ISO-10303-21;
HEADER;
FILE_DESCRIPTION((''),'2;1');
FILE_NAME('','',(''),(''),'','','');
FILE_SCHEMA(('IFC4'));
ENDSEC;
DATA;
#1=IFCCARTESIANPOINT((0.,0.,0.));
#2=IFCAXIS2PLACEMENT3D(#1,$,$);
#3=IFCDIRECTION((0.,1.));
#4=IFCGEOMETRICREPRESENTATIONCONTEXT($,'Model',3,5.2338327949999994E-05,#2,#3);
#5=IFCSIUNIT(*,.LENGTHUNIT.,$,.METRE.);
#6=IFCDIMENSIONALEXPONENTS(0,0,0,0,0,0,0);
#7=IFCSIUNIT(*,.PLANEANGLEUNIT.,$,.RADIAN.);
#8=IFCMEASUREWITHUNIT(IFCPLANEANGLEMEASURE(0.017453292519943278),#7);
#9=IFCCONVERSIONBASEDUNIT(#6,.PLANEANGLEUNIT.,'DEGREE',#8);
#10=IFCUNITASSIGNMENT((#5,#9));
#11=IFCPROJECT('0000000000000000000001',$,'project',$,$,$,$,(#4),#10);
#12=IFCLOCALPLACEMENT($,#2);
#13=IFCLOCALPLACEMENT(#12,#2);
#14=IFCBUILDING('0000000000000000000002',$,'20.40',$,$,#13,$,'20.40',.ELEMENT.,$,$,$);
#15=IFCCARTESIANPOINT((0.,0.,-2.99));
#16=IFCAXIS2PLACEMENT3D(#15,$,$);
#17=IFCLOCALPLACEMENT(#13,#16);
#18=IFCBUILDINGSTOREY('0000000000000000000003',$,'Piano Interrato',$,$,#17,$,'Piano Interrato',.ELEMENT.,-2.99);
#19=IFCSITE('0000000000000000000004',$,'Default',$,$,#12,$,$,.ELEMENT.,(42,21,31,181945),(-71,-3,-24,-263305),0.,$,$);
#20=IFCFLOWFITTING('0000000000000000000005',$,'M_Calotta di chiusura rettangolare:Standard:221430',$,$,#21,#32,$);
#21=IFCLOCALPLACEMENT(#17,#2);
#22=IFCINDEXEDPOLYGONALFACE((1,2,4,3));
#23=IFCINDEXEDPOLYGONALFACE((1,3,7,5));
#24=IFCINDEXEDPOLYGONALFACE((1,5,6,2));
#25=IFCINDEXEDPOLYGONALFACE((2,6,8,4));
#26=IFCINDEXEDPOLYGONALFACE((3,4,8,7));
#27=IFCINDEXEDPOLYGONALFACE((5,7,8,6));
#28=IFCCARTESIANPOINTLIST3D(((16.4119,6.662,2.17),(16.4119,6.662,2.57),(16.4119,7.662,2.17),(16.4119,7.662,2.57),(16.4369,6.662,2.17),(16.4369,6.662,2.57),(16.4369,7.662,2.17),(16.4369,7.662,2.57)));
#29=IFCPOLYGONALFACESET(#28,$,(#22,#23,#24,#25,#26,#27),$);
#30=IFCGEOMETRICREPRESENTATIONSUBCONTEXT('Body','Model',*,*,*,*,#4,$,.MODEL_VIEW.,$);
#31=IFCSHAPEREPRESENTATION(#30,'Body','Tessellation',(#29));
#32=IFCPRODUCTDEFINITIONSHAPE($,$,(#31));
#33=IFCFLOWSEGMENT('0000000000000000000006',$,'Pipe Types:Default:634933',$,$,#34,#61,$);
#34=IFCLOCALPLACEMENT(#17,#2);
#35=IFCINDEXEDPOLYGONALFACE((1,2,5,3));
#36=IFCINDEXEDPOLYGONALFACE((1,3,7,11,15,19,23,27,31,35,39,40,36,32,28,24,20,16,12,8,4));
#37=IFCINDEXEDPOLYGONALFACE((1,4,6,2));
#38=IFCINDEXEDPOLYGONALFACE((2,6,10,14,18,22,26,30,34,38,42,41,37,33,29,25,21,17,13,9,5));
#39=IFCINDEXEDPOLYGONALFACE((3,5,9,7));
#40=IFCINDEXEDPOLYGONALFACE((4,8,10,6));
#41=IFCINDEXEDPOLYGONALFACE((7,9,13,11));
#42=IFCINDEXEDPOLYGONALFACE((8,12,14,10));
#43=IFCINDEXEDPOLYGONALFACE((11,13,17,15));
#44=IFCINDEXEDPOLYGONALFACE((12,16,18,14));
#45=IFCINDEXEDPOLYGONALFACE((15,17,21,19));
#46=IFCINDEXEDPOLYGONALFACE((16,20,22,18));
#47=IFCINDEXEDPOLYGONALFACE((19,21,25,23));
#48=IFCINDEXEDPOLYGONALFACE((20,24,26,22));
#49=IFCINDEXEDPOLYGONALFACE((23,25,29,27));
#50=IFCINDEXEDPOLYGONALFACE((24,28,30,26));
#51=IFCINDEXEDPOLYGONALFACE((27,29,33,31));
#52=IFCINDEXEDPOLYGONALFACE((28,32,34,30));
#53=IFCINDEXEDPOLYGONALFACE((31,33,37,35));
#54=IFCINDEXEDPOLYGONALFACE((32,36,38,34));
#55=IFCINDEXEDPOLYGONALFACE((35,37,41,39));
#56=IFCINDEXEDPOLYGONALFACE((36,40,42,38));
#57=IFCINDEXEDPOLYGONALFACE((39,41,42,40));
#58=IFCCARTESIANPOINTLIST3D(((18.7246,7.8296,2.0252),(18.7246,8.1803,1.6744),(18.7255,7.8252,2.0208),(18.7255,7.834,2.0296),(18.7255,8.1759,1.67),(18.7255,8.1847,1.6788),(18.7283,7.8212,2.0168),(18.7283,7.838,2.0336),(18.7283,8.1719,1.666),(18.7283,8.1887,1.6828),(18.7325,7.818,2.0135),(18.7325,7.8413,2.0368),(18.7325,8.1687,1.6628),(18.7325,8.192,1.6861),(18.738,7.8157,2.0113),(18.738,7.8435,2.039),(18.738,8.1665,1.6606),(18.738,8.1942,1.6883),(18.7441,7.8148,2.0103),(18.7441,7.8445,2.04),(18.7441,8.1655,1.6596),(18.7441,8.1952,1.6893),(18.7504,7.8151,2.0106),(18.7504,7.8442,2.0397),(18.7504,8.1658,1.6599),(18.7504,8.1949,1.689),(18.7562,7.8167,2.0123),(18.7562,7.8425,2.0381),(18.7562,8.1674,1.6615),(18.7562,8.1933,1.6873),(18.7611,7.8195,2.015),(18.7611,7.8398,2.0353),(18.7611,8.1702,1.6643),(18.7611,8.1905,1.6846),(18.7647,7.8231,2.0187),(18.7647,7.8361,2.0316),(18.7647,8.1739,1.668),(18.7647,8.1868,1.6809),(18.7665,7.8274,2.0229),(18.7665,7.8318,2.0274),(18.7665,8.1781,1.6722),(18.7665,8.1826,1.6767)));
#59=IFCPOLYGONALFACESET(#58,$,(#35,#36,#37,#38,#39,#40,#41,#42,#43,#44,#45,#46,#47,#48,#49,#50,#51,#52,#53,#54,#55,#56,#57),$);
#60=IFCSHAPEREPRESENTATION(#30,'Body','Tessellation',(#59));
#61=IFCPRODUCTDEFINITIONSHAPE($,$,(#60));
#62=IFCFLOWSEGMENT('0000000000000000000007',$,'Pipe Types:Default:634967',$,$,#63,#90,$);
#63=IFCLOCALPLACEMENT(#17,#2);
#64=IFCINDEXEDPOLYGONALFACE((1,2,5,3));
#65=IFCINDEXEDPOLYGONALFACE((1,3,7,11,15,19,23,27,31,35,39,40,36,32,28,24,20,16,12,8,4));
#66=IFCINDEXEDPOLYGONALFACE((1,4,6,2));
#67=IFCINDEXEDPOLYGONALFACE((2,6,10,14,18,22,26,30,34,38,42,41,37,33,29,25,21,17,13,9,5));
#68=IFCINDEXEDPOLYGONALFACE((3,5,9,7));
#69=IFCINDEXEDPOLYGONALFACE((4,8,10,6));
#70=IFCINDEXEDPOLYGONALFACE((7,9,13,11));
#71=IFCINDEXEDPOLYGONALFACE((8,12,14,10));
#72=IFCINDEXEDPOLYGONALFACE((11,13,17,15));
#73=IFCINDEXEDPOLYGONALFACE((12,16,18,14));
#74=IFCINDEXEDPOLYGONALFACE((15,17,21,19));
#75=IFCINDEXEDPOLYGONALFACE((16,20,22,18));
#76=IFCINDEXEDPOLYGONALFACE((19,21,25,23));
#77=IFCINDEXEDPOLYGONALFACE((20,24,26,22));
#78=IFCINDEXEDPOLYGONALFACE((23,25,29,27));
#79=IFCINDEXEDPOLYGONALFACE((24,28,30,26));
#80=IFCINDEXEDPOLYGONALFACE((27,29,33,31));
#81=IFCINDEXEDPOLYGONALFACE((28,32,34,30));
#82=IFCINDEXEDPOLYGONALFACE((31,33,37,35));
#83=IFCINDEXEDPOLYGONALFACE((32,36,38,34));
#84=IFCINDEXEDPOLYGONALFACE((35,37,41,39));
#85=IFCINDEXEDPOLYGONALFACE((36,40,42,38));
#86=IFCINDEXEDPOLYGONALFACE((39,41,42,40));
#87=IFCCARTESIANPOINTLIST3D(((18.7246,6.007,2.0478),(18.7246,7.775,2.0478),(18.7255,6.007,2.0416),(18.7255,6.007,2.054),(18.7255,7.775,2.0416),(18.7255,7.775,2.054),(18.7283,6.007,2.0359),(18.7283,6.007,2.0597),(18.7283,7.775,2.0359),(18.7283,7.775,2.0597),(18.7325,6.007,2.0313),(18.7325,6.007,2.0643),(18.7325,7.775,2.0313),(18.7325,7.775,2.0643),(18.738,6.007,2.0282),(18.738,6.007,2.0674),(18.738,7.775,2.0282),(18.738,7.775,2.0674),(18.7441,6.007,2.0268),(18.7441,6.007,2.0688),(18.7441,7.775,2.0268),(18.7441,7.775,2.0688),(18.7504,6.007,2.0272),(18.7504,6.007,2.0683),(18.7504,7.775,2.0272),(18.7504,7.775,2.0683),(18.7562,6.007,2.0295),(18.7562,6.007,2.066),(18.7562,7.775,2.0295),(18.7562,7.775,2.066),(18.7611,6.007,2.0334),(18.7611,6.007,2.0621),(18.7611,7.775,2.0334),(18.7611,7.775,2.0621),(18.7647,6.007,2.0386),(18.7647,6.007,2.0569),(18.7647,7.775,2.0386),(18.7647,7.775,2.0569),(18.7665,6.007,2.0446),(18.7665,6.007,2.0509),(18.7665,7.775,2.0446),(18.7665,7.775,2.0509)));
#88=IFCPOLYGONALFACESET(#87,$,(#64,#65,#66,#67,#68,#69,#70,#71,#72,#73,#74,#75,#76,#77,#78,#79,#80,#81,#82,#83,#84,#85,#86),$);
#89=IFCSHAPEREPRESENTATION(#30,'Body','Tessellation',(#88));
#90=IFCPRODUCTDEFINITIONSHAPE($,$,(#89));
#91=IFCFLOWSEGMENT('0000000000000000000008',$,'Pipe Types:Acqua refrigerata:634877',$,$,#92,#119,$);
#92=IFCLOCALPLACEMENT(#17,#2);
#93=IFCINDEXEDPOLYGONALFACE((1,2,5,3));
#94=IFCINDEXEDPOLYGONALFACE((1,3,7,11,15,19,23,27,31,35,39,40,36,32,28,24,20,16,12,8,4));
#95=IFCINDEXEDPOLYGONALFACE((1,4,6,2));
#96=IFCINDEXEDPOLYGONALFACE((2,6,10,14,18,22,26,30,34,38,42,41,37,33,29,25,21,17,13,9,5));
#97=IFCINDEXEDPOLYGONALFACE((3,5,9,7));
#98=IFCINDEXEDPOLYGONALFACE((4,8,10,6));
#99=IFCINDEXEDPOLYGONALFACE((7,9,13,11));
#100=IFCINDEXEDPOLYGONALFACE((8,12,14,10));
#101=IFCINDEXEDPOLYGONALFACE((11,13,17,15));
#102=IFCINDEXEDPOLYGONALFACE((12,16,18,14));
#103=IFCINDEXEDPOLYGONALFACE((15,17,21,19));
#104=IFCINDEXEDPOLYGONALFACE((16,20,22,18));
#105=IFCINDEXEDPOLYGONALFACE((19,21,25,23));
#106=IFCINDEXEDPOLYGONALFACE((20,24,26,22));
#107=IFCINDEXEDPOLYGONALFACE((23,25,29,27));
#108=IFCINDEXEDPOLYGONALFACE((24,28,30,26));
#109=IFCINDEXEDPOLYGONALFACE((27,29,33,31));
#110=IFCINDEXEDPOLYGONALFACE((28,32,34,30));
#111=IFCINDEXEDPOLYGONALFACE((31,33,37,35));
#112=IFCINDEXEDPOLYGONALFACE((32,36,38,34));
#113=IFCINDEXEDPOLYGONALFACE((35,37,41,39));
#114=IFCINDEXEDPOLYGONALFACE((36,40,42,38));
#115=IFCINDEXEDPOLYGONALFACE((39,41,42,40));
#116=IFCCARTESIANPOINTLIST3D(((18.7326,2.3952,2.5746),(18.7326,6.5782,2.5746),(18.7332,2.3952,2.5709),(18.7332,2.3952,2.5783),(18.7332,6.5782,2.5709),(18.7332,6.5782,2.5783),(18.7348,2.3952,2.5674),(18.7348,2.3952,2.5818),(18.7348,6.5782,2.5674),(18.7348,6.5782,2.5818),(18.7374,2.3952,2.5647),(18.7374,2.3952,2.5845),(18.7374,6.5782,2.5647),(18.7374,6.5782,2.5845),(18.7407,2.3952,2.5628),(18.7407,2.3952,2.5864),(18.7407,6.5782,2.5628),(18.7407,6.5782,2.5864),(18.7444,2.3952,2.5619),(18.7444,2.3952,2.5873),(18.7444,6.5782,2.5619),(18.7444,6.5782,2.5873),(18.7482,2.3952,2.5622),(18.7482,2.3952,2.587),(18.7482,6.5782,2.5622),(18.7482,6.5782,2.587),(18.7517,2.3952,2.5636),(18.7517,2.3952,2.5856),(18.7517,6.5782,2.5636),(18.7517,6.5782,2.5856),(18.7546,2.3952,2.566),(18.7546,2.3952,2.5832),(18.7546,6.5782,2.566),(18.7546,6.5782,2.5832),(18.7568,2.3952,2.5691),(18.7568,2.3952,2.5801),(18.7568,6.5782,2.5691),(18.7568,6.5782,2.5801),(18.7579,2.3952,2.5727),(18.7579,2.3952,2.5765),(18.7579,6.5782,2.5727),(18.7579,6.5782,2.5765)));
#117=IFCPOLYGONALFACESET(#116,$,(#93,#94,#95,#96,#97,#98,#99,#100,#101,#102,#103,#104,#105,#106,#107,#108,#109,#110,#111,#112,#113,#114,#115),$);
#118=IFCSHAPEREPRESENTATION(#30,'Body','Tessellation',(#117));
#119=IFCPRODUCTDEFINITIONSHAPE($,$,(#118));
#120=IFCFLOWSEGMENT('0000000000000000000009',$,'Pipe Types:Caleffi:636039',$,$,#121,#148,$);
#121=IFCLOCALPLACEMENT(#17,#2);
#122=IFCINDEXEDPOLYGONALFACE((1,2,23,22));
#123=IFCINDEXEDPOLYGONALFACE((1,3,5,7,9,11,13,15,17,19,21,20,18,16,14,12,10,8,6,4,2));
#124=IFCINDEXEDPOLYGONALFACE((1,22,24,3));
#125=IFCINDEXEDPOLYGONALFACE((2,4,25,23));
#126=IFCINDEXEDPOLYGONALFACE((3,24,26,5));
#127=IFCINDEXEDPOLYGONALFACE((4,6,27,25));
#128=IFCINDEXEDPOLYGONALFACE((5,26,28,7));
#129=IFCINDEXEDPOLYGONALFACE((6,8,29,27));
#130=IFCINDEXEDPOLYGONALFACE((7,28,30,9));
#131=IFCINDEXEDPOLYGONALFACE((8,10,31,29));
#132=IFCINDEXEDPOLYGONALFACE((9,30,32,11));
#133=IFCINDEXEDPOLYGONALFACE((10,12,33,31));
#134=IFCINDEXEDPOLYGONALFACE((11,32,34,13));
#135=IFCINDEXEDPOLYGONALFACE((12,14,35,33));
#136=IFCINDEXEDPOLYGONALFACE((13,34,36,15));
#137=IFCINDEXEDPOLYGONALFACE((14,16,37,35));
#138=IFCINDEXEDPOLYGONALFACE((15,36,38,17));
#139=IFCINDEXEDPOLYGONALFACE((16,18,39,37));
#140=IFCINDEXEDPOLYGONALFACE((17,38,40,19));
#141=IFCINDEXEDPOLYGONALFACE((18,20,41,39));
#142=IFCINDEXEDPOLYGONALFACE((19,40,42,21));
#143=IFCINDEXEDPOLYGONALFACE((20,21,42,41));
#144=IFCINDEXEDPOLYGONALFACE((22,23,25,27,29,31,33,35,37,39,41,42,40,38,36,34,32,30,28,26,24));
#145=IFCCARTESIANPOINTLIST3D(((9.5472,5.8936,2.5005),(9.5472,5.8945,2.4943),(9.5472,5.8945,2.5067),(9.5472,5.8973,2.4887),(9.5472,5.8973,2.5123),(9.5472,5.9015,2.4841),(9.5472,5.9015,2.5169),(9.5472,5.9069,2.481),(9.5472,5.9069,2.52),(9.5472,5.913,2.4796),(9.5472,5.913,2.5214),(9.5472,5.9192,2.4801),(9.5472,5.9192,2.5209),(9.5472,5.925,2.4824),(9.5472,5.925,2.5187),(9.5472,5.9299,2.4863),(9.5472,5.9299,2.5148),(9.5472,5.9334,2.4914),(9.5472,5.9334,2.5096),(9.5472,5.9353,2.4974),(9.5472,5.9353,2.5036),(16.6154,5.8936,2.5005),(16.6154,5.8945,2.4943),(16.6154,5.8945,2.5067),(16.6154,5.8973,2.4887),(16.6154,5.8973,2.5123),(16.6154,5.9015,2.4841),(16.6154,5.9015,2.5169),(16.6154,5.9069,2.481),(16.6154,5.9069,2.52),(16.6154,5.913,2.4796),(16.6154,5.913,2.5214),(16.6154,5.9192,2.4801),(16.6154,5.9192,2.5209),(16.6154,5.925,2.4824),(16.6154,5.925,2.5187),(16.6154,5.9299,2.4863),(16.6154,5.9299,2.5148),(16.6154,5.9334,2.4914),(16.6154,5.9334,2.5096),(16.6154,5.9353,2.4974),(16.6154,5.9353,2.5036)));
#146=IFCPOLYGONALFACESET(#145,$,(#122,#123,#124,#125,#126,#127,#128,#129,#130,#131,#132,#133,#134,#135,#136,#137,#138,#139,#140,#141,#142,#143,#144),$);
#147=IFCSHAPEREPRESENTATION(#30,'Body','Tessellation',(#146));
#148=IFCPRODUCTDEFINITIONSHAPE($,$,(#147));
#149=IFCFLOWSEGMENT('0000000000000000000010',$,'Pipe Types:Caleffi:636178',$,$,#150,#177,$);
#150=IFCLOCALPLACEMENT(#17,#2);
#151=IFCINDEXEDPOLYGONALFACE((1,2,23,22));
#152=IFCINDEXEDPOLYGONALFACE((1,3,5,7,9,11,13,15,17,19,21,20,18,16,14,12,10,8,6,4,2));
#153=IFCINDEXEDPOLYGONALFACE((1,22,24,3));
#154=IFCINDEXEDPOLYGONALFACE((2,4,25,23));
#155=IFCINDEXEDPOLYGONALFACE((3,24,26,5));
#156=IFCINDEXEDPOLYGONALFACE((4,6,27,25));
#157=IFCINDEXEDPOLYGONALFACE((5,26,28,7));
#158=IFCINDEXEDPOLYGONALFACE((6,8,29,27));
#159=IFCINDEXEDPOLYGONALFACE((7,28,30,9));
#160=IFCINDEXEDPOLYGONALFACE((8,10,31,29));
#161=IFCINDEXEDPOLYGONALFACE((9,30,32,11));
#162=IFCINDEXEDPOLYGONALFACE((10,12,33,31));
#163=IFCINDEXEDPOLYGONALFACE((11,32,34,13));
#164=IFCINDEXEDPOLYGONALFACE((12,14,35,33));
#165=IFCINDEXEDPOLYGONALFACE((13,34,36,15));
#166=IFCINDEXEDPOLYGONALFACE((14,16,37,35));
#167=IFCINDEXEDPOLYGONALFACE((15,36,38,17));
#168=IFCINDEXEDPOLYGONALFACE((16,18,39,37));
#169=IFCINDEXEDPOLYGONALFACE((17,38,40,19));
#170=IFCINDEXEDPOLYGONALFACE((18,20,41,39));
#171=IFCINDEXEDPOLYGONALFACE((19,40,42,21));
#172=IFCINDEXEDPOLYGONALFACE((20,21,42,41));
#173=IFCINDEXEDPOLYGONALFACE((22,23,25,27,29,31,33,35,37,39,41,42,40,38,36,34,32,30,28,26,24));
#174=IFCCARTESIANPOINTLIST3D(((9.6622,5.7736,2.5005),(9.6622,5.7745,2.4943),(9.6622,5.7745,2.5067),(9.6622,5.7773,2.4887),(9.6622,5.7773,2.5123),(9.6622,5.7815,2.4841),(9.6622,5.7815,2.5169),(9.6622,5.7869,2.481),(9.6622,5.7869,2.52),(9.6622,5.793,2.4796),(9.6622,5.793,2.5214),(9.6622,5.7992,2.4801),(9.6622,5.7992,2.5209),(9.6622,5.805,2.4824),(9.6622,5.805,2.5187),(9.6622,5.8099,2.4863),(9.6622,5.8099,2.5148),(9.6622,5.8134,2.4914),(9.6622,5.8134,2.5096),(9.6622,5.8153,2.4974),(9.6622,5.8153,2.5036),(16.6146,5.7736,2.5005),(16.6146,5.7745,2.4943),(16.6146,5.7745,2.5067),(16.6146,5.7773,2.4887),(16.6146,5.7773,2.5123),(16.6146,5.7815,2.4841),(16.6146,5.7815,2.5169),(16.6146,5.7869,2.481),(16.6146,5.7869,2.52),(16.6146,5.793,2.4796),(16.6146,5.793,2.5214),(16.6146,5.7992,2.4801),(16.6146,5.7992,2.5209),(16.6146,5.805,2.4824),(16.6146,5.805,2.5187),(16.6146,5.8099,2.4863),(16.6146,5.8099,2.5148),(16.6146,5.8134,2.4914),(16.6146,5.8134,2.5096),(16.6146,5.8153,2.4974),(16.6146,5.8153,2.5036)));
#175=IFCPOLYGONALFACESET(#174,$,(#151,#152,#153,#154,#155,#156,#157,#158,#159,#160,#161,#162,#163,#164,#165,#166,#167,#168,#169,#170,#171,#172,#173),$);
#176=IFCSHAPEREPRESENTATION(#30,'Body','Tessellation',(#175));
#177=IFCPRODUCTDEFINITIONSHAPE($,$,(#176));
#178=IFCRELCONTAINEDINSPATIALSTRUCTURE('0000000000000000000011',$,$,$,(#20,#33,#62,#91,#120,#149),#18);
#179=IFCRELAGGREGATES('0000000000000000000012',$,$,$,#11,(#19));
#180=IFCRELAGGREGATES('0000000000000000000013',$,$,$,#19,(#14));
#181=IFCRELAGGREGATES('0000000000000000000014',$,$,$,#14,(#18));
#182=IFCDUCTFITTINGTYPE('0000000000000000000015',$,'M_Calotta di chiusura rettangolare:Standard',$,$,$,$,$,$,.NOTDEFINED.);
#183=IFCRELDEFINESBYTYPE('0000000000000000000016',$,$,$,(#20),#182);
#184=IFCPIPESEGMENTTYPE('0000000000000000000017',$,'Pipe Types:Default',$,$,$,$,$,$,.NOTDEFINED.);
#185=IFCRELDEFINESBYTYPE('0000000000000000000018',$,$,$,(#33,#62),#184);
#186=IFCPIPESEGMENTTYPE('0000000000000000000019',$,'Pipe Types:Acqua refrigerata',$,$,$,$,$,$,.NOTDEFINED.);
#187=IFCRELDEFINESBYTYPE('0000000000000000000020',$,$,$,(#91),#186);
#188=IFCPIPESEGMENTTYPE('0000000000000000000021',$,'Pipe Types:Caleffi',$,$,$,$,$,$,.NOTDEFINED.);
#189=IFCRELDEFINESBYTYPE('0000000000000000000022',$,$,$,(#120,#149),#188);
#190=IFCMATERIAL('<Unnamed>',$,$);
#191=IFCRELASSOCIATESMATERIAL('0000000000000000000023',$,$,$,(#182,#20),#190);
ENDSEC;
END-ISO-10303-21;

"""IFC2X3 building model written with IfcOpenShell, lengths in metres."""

from ifc_helpers import new_model, entity, si_unit, converted_unit, direction, frame, frame_2d, origin, origin_2d_with_axis, place, context, subcontext, project, spatial, rectangle, circle, extrude, source, transform, mapped, material, type_object, type_shapes, element, save


model = new_model("IFC2X3")

# Units and contexts
model_context = context("Model", 3, precision=5.2338327949999994e-05, world=origin(), true_north=direction((0.0, 1.0)))
body_context = subcontext(model_context, "Body", "Model", "MODEL_VIEW")
ifc_project = project(units=[si_unit("LENGTHUNIT", "METRE"), converted_unit("PLANEANGLEUNIT", "DEGREE", entity("IfcPlaneAngleMeasure", 0.017453292519943278), si_unit("PLANEANGLEUNIT", "RADIAN"), dimensions=[0, 0, 0, 0, 0, 0, 0])], contexts=[model_context])

# Site, building, storey
site_placement = place(None, origin())
site = spatial("IfcSite", under=ifc_project, at=site_placement, Name="Default", CompositionType="ELEMENT", RefLatitude=(42, 21, 31, 181945), RefLongitude=(-71, -3, -24, -263305), RefElevation=0.0)
building_placement = place(site_placement, origin())
building = spatial("IfcBuilding", under=site, at=building_placement, Name="20.40", LongName="20.40", CompositionType="ELEMENT")
storey_placement = place(building_placement, frame((0.0, 0.0, -2.99)))
storey = spatial("IfcBuildingStorey", under=building, at=storey_placement, Name="Piano Interrato", LongName="Piano Interrato", CompositionType="ELEMENT", Elevation=-2.99)

# Flow fitting
ifc_material = material(Name="<Unnamed>")
duct_fitting_type = type_object("IfcDuctFittingType", Name="M_Calotta di chiusura rettangolare:Standard", PredefinedType="NOTDEFINED", material=ifc_material)
shared_shape_1 = source(origin(), body_context, "Body", "SweptSolid", [
    extrude(rectangle(XDim=0.025, YDim=1.0, at=frame_2d((0.0, 0.0), x_axis=(1.0, 0.0))), frame((0.0125, 0.0, -0.2)), (0.0, 0.0, 1.0), 0.4),
])
type_shapes(duct_fitting_type, [shared_shape_1])
flow_fitting_placement = place(storey_placement, frame((16.4369, 7.162, 2.37), z_axis=(0.0, 0.0, 1.0), x_axis=(-1.0, 0.0, 0.0)))
element("IfcFlowFitting", 1, at=flow_fitting_placement, inside=storey, type_object=duct_fitting_type, material=ifc_material, Name="M_Calotta di chiusura rettangolare:Standard:221430", context=body_context, shape_type="MappedRepresentation", body=[
    mapped(shared_shape_1, transform((0.0, 0.0, 0.0), scale=1.0)),
])

# Flow segments
pipe_segment_type_1 = type_object("IfcPipeSegmentType", Name="Pipe Types:Default", PredefinedType="NOTDEFINED")
flow_segment_1_placement = place(storey_placement, origin())
element("IfcFlowSegment", 2, at=flow_segment_1_placement, inside=storey, type_object=pipe_segment_type_1, Name="Pipe Types:Default:634933", context=body_context, shape_type="SweptSolid", body=[
    extrude(circle(Radius=0.0211, at=frame_2d((0.0, 0.0), x_axis=(1.0, 0.0))), frame((18.7457, 7.8296, 2.0252), z_axis=(0.0, 0.707107, -0.707107), x_axis=(-1.0, 0.0, 0.0)), (0.0, 0.0, 1.0), 0.496),
])
flow_segment_2_placement = place(storey_placement, origin())
element("IfcFlowSegment", 3, at=flow_segment_2_placement, inside=storey, type_object=pipe_segment_type_1, Name="Pipe Types:Default:634967", context=body_context, shape_type="SweptSolid", body=[
    extrude(circle(Radius=0.0211, at=frame_2d((0.0, 0.0), x_axis=(1.0, 0.0))), frame((18.7457, 6.007, 2.0478), z_axis=(0.0, 1.0, 0.0), x_axis=(-1.0, 0.0, 0.0)), (0.0, 0.0, 1.0), 1.768),
])
pipe_segment_type_2 = type_object("IfcPipeSegmentType", Name="Pipe Types:Acqua refrigerata", PredefinedType="NOTDEFINED")
flow_segment_3_placement = place(storey_placement, origin())
element("IfcFlowSegment", 4, at=flow_segment_3_placement, inside=storey, type_object=pipe_segment_type_2, Name="Pipe Types:Acqua refrigerata:634877", context=body_context, shape_type="SweptSolid", body=[
    extrude(circle(Radius=0.0127, at=origin_2d_with_axis()), frame((18.7453, 2.3952, 2.5746), z_axis=(0.0, 1.0, 0.0), x_axis=(-1.0, 0.0, 0.0)), (0.0, 0.0, 1.0), 4.183),
])
pipe_segment_type_3 = type_object("IfcPipeSegmentType", Name="Pipe Types:Caleffi", PredefinedType="NOTDEFINED")
flow_segment_4_placement = place(storey_placement, origin())
element("IfcFlowSegment", 5, at=flow_segment_4_placement, inside=storey, type_object=pipe_segment_type_3, Name="Pipe Types:Caleffi:636039", context=body_context, shape_type="SweptSolid", body=[
    extrude(circle(Radius=0.0209, at=origin_2d_with_axis()), frame((9.5472, 5.9146, 2.5005), z_axis=(1.0, 0.0, 0.0), x_axis=(0.0, -1.0, 0.0)), (0.0, 0.0, 1.0), 7.0681),
])
flow_segment_5_placement = place(storey_placement, origin())
element("IfcFlowSegment", 6, at=flow_segment_5_placement, inside=storey, type_object=pipe_segment_type_3, Name="Pipe Types:Caleffi:636178", context=body_context, shape_type="SweptSolid", body=[
    extrude(circle(Radius=0.0209, at=origin_2d_with_axis()), frame((9.6622, 5.7946, 2.5005), z_axis=(1.0, 0.0, 0.0), x_axis=(0.0, -1.0, 0.0)), (0.0, 0.0, 1.0), 6.9524),
])

save(model, "model.ifc")
